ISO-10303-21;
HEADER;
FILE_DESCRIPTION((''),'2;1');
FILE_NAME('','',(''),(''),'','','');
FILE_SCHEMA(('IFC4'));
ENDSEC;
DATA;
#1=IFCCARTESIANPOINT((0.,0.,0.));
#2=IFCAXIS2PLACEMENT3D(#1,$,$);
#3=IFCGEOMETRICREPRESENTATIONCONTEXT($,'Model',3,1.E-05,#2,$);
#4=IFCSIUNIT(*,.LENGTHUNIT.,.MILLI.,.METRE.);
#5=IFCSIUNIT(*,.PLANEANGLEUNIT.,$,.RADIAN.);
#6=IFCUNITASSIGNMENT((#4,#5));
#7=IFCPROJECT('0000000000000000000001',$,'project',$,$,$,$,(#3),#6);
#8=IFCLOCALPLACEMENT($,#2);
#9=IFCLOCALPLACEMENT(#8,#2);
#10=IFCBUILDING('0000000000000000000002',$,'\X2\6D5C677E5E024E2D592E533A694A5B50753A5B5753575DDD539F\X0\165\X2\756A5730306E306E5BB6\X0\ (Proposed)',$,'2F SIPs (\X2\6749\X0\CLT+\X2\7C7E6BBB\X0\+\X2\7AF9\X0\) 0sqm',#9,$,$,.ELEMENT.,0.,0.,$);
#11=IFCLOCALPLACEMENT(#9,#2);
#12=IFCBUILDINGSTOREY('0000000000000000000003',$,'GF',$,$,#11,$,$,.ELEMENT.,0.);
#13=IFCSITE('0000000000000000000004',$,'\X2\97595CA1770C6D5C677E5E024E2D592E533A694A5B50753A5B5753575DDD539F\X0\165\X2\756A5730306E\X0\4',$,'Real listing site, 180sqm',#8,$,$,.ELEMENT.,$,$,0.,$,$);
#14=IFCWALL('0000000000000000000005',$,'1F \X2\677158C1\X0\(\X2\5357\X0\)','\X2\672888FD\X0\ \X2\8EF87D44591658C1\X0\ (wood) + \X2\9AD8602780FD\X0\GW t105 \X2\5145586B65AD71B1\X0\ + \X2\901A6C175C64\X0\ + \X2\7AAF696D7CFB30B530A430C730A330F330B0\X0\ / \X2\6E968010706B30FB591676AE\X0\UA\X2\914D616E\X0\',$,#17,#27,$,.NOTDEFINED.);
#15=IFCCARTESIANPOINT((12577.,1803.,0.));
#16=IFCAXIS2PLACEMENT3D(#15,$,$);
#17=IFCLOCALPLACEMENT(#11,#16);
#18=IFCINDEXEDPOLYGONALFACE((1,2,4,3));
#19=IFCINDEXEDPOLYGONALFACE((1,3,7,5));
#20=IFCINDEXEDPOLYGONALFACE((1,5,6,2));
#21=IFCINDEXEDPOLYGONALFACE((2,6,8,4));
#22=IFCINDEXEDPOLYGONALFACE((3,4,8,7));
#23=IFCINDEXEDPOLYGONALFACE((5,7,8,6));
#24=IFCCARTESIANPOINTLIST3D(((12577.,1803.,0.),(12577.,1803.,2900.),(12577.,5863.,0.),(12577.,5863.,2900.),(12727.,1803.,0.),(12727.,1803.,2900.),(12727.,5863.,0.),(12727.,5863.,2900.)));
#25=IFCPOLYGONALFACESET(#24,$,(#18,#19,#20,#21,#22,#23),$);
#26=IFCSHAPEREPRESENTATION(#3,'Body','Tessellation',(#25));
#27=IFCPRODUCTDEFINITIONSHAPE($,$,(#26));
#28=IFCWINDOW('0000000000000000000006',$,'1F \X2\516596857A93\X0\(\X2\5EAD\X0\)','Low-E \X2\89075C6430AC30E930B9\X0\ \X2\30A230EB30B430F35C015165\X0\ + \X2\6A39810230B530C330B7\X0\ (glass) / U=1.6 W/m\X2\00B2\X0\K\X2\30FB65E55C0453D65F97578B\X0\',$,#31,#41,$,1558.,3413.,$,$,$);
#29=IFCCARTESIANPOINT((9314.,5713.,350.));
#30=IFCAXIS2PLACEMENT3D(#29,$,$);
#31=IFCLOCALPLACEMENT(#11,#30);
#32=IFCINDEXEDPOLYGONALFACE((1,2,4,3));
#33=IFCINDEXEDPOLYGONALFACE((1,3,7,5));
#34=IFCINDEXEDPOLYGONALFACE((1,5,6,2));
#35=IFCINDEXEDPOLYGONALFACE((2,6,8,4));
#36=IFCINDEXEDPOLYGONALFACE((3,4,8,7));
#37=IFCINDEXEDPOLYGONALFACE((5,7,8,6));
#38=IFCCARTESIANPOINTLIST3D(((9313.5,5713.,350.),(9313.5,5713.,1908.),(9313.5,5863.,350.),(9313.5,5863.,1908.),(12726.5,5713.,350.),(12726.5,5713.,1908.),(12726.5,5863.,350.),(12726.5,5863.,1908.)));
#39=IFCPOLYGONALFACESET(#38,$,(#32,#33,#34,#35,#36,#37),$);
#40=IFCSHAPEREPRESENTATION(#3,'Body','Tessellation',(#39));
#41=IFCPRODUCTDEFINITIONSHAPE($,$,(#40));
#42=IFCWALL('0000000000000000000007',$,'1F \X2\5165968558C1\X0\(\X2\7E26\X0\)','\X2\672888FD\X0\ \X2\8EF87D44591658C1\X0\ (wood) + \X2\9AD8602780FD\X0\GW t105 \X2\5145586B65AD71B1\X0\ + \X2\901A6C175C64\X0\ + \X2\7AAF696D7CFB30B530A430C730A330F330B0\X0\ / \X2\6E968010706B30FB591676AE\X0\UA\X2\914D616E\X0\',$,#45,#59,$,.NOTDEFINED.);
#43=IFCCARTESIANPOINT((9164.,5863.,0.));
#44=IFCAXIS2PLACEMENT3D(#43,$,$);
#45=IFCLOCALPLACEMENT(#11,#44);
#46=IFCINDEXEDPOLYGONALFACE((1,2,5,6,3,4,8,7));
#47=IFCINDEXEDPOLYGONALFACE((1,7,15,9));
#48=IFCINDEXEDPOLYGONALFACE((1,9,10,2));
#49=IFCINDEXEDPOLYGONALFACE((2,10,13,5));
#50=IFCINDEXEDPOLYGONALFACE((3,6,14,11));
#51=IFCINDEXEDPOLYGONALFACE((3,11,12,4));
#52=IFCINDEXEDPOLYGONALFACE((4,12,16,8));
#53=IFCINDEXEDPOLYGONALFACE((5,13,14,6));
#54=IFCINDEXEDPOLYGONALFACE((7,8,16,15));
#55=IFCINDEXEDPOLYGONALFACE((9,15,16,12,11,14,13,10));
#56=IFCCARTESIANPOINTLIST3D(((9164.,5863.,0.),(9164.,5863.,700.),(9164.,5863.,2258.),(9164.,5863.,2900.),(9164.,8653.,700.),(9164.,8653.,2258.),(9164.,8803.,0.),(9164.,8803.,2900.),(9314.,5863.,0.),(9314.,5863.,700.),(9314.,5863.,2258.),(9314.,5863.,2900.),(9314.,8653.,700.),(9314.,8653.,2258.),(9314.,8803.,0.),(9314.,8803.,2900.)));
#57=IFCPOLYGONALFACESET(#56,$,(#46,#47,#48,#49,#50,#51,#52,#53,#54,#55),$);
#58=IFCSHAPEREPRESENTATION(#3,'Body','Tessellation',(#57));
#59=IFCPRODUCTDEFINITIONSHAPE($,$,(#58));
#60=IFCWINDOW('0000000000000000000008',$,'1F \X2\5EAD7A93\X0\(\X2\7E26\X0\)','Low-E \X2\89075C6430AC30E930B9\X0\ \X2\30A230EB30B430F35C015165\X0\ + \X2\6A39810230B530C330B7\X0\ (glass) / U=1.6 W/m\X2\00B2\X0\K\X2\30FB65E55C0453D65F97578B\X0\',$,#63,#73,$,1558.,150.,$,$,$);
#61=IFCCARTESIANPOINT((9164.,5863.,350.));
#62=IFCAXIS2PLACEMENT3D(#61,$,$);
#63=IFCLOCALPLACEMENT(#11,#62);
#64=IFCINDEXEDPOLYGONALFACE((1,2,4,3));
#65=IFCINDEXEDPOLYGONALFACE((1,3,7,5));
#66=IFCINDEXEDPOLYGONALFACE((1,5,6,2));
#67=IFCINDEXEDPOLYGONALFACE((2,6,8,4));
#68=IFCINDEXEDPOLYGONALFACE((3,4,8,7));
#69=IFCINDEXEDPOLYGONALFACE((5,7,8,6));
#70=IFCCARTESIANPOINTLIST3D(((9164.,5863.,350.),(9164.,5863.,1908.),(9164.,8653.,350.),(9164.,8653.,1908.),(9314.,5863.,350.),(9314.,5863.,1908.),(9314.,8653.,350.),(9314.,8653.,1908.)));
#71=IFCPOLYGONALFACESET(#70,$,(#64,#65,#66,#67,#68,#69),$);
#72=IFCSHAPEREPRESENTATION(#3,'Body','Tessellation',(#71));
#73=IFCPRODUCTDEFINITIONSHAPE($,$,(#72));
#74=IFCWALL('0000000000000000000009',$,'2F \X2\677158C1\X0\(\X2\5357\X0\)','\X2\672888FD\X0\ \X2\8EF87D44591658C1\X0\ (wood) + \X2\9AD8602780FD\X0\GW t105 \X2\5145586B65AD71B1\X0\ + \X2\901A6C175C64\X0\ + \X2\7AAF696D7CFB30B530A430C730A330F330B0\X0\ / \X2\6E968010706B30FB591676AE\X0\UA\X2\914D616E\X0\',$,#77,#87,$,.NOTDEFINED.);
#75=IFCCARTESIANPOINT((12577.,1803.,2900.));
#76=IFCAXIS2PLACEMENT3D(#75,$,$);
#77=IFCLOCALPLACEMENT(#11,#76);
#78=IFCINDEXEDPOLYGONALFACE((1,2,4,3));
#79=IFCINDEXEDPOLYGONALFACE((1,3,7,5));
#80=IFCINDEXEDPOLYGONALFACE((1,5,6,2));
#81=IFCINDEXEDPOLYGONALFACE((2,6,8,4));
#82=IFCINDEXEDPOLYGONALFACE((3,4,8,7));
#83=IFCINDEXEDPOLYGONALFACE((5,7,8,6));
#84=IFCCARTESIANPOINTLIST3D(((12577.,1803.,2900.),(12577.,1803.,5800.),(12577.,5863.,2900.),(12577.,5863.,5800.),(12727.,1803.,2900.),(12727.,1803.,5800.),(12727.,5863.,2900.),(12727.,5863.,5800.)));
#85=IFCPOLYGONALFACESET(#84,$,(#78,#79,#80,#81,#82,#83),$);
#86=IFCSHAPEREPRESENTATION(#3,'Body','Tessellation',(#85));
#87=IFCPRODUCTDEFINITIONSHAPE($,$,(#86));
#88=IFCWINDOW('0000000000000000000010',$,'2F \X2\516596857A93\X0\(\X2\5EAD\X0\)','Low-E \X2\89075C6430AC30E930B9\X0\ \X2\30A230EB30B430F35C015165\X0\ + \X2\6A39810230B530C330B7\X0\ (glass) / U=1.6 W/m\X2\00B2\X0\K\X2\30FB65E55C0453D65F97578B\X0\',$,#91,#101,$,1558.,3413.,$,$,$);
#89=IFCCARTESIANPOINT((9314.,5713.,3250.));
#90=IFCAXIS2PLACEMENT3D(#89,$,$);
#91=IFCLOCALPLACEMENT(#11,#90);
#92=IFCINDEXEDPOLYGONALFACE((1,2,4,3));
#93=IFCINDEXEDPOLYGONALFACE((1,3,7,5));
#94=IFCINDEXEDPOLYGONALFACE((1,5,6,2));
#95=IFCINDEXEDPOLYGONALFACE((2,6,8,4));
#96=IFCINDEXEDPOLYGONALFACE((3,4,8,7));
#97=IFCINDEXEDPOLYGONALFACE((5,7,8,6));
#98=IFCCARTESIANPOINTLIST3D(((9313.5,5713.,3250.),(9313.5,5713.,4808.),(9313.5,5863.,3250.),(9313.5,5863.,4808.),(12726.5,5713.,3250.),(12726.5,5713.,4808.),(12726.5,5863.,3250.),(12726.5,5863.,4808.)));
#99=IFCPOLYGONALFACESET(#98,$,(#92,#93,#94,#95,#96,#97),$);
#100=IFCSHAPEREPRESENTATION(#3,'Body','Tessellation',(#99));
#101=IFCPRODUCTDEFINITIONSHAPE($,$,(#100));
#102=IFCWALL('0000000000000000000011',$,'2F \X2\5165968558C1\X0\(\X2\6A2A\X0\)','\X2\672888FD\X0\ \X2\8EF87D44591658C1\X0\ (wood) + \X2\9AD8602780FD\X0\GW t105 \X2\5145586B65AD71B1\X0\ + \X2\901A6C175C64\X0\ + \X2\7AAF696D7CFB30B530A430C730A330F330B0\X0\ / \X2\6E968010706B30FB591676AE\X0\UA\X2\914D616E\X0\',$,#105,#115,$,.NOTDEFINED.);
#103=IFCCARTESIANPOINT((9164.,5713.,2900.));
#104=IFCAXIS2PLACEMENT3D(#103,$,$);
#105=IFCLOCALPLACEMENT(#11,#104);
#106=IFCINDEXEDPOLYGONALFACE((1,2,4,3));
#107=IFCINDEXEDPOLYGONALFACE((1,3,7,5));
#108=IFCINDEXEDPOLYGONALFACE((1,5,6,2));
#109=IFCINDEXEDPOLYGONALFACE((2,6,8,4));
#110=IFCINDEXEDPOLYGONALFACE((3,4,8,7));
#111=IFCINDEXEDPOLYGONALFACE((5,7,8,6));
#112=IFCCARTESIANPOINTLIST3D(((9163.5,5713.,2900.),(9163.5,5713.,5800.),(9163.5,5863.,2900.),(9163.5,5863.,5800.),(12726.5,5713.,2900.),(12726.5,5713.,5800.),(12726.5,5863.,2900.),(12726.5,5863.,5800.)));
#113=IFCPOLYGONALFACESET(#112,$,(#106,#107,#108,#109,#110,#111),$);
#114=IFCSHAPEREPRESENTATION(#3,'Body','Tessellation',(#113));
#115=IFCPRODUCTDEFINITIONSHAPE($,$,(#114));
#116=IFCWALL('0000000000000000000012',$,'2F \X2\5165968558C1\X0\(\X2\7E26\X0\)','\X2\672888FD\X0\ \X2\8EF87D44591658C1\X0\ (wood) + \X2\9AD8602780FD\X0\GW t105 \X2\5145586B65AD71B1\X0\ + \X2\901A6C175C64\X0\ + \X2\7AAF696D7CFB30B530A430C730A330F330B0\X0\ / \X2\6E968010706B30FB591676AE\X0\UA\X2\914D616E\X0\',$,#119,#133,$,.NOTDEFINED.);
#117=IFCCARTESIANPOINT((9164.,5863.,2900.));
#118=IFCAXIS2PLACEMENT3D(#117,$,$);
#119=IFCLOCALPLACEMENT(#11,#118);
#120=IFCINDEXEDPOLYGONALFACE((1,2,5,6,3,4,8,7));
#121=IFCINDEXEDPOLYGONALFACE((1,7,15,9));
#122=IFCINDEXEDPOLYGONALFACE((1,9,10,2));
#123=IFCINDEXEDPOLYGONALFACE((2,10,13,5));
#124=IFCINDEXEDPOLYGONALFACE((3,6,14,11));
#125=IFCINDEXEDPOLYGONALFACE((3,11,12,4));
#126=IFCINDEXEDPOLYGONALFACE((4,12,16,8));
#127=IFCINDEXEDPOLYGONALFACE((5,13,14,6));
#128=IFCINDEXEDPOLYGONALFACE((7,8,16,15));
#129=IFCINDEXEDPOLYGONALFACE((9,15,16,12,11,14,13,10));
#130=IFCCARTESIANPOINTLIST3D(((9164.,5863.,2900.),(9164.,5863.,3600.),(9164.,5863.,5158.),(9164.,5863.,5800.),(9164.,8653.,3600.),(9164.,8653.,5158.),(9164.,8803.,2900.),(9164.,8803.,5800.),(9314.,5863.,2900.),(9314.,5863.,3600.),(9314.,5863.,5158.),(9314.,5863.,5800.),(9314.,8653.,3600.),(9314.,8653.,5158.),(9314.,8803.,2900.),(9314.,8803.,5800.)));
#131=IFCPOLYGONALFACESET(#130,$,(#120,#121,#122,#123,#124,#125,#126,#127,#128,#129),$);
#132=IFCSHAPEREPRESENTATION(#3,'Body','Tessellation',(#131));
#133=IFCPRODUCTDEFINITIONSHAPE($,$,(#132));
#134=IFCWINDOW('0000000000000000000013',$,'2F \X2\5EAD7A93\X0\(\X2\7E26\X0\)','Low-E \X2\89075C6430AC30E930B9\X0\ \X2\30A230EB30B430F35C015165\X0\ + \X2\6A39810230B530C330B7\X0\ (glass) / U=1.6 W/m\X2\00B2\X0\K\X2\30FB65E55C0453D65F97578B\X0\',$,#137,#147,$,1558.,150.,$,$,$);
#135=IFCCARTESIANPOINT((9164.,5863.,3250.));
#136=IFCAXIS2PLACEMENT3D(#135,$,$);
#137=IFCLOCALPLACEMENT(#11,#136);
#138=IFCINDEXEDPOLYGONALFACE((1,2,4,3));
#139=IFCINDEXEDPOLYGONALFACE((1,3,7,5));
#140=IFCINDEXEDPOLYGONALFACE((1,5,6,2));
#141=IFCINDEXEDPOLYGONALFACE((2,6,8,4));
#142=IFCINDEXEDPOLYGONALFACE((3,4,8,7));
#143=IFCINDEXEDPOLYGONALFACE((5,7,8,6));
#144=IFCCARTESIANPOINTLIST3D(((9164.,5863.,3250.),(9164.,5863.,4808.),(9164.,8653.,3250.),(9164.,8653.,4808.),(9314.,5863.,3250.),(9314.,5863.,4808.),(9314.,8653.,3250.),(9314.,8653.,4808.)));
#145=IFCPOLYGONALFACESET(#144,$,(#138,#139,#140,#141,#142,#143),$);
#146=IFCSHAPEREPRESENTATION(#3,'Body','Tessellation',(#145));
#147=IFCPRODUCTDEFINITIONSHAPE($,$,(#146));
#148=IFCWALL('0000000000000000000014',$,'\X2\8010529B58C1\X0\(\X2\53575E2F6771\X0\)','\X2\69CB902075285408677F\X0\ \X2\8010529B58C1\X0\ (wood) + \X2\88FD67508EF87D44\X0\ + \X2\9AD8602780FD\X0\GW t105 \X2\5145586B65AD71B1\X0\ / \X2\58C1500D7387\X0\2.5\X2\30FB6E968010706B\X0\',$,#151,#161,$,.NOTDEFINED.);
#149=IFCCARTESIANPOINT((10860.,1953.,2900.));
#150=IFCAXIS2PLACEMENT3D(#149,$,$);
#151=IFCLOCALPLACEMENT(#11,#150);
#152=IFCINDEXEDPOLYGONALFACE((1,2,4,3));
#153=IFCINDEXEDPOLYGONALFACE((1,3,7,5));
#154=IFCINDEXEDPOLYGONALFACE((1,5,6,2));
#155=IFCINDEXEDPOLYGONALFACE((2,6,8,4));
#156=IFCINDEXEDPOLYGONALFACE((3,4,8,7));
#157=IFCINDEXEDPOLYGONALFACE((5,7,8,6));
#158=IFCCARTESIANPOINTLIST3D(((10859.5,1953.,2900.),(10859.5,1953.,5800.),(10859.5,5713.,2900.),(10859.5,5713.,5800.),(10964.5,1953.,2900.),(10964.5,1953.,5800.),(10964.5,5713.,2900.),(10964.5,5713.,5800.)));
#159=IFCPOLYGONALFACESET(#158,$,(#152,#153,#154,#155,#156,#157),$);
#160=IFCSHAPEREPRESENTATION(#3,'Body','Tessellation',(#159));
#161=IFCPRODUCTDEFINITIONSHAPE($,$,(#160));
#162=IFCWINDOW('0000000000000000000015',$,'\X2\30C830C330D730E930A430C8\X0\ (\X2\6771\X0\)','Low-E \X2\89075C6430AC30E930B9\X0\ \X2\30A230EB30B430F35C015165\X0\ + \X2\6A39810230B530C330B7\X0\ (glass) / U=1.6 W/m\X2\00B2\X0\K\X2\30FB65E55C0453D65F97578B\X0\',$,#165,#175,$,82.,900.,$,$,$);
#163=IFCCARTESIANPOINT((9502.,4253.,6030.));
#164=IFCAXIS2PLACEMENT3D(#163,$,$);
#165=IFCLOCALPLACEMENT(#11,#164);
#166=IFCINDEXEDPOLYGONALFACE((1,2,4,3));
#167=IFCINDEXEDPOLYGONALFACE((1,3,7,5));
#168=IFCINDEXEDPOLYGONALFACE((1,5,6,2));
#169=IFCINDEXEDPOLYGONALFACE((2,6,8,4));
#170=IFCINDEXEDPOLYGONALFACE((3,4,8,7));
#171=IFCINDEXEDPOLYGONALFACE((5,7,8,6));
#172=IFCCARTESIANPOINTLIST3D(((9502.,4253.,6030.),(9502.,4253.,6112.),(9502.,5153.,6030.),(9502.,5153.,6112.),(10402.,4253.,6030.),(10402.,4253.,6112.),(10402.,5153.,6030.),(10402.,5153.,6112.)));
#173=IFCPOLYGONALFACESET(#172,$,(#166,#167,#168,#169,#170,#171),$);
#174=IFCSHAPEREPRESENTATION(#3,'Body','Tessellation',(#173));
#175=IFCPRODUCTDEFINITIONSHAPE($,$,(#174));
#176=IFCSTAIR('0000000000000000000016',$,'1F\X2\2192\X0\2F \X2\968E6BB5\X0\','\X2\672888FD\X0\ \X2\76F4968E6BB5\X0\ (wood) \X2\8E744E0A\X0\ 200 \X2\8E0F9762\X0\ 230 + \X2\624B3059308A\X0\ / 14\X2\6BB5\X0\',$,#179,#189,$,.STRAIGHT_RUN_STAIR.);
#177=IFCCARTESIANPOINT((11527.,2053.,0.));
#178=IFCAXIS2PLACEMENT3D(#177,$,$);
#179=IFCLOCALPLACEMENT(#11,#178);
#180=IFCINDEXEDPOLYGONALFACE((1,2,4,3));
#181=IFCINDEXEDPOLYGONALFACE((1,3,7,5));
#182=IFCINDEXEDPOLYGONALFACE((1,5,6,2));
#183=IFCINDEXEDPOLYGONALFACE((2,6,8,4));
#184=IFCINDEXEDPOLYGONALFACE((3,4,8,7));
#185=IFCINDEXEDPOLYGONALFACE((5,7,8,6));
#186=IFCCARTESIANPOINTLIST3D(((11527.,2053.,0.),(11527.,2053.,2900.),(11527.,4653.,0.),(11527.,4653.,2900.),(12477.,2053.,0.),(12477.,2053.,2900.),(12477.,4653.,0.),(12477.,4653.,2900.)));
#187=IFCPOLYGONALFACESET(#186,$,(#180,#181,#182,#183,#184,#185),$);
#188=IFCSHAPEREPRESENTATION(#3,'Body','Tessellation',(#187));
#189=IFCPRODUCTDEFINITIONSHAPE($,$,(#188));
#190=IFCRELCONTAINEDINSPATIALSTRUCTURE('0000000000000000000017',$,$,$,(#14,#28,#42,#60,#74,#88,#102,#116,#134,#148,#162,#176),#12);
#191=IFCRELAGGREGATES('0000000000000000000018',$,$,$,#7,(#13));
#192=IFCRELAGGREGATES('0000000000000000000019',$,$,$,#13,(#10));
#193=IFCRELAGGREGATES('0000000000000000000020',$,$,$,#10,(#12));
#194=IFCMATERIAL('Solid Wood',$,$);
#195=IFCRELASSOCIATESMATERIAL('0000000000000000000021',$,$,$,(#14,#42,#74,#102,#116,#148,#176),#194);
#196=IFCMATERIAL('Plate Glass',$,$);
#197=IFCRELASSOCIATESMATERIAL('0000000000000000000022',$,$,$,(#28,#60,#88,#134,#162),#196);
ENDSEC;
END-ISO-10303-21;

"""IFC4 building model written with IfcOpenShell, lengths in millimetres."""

from ifc_helpers import new_model, si_unit, frame, frame_2d, origin, place, context, project, spatial, rectangle, extrude, material, element, fill, save


model = new_model("IFC4")

# Units and contexts
model_context = context("Model", 3, precision=1e-05, world=origin())
ifc_project = project(units=[si_unit("LENGTHUNIT", "METRE", prefix="MILLI"), si_unit("PLANEANGLEUNIT", "RADIAN")], contexts=[model_context])

# Site, building, storey
site_placement = place(None, origin())
site = spatial("IfcSite", under=ifc_project, at=site_placement, Name="静岡県浜松市中央区楊子町字南川原165番地の4", ObjectType="Real listing site, 180sqm", CompositionType="ELEMENT", RefElevation=0.0)
building_placement = place(site_placement, origin())
building = spatial("IfcBuilding", under=site, at=building_placement, Name="浜松市中央区楊子町字南川原165番地のの家 (Proposed)", ObjectType="2F SIPs (杉CLT+籾殻+竹) 0sqm", CompositionType="ELEMENT", ElevationOfRefHeight=0.0, ElevationOfTerrain=0.0)
storey_placement = place(building_placement, origin())
storey = spatial("IfcBuildingStorey", under=building, at=storey_placement, Name="GF", CompositionType="ELEMENT", Elevation=0.0)

# Shared definitions
ifc_material_1 = material(Name="Solid Wood")

# Wall, opening, window
wall_1_placement = place(storey_placement, frame((12577.0, 1803.0, 0.0)))
wall_1 = element("IfcWall", 1, at=wall_1_placement, inside=storey, material=ifc_material_1, Name="1F 東壁(南)", Description="木製 軸組外壁 (wood) + 高性能GW t105 充填断熱 + 通気層 + 窯業系サイディング / 準耐火・外皮UA配慮", PredefinedType="NOTDEFINED", context=model_context, shape_type="SweptSolid", body=[
    extrude(rectangle(XDim=150.0, YDim=4060.0, at=frame_2d((75.0, 2030.0))), frame((12577.0, 1803.0, 0.0)), (0.0, 0.0, 1.0), 2900.0),
])
opening_1_placement = place(storey_placement, frame((9314.0, 5713.0, 350.0)))
opening_1 = element("IfcOpeningElement", 2, at=opening_1_placement, cuts=wall_1, PredefinedType="NOTDEFINED", context=model_context, shape_type="SweptSolid", body=[
    extrude(rectangle(XDim=3413.0, YDim=150.0, at=frame_2d((1706.0, 75.0))), frame((9314.0, 5713.0, 350.0)), (0.0, 0.0, 1.0), 1558.0),
])
ifc_material_2 = material(Name="Plate Glass")
window_1_placement = place(storey_placement, frame((9314.0, 5713.0, 350.0)))
window_1 = element("IfcWindow", 3, at=window_1_placement, inside=storey, material=ifc_material_2, Name="1F 入隅窓(庭)", Description="Low-E 複層ガラス アルゴン封入 + 樹脂サッシ (glass) / U=1.6 W/m²K・日射取得型", OverallHeight=1558.0, OverallWidth=3413.0, context=model_context, shape_type="SweptSolid", body=[
    extrude(rectangle(XDim=3413.0, YDim=150.0, at=frame_2d((1706.0, 75.0))), frame((9314.0, 5713.0, 350.0)), (0.0, 0.0, 1.0), 1558.0),
])
fill(opening_1, window_1)

# Wall, opening, window
wall_2_placement = place(storey_placement, frame((9164.0, 5863.0, 0.0)))
wall_2 = element("IfcWall", 4, at=wall_2_placement, inside=storey, material=ifc_material_1, Name="1F 入隅壁(縦)", Description="木製 軸組外壁 (wood) + 高性能GW t105 充填断熱 + 通気層 + 窯業系サイディング / 準耐火・外皮UA配慮", PredefinedType="NOTDEFINED", context=model_context, shape_type="SweptSolid", body=[
    extrude(rectangle(XDim=150.0, YDim=2940.0, at=frame_2d((75.0, 1470.0))), frame((9164.0, 5863.0, 0.0)), (0.0, 0.0, 1.0), 2900.0),
])
opening_2_placement = place(storey_placement, frame((9164.0, 5863.0, 350.0)))
opening_2 = element("IfcOpeningElement", 5, at=opening_2_placement, cuts=wall_2, PredefinedType="NOTDEFINED", context=model_context, shape_type="SweptSolid", body=[
    extrude(rectangle(XDim=150.0, YDim=2790.0, at=frame_2d((75.0, 1395.0))), frame((9164.0, 5863.0, 350.0)), (0.0, 0.0, 1.0), 1558.0),
])
window_2_placement = place(storey_placement, frame((9164.0, 5863.0, 350.0)))
window_2 = element("IfcWindow", 6, at=window_2_placement, inside=storey, material=ifc_material_2, Name="1F 庭窓(縦)", Description="Low-E 複層ガラス アルゴン封入 + 樹脂サッシ (glass) / U=1.6 W/m²K・日射取得型", OverallHeight=1558.0, OverallWidth=150.0, context=model_context, shape_type="SweptSolid", body=[
    extrude(rectangle(XDim=150.0, YDim=2790.0, at=frame_2d((75.0, 1395.0))), frame((9164.0, 5863.0, 350.0)), (0.0, 0.0, 1.0), 1558.0),
])
fill(opening_2, window_2)

# Wall, opening, window
wall_3_placement = place(storey_placement, frame((12577.0, 1803.0, 2900.0)))
wall_3 = element("IfcWall", 7, at=wall_3_placement, inside=storey, material=ifc_material_1, Name="2F 東壁(南)", Description="木製 軸組外壁 (wood) + 高性能GW t105 充填断熱 + 通気層 + 窯業系サイディング / 準耐火・外皮UA配慮", PredefinedType="NOTDEFINED", context=model_context, shape_type="SweptSolid", body=[
    extrude(rectangle(XDim=150.0, YDim=4060.0, at=frame_2d((75.0, 2030.0))), frame((12577.0, 1803.0, 2900.0)), (0.0, 0.0, 1.0), 2900.0),
])
opening_3_placement = place(storey_placement, frame((9314.0, 5713.0, 3250.0)))
opening_3 = element("IfcOpeningElement", 8, at=opening_3_placement, cuts=wall_3, PredefinedType="NOTDEFINED", context=model_context, shape_type="SweptSolid", body=[
    extrude(rectangle(XDim=3413.0, YDim=150.0, at=frame_2d((1706.0, 75.0))), frame((9314.0, 5713.0, 3250.0)), (0.0, 0.0, 1.0), 1558.0),
])
window_3_placement = place(storey_placement, frame((9314.0, 5713.0, 3250.0)))
window_3 = element("IfcWindow", 9, at=window_3_placement, inside=storey, material=ifc_material_2, Name="2F 入隅窓(庭)", Description="Low-E 複層ガラス アルゴン封入 + 樹脂サッシ (glass) / U=1.6 W/m²K・日射取得型", OverallHeight=1558.0, OverallWidth=3413.0, context=model_context, shape_type="SweptSolid", body=[
    extrude(rectangle(XDim=3413.0, YDim=150.0, at=frame_2d((1706.0, 75.0))), frame((9314.0, 5713.0, 3250.0)), (0.0, 0.0, 1.0), 1558.0),
])
fill(opening_3, window_3)

# Wall
wall_4_placement = place(storey_placement, frame((9164.0, 5713.0, 2900.0)))
element("IfcWall", 10, at=wall_4_placement, inside=storey, material=ifc_material_1, Name="2F 入隅壁(横)", Description="木製 軸組外壁 (wood) + 高性能GW t105 充填断熱 + 通気層 + 窯業系サイディング / 準耐火・外皮UA配慮", PredefinedType="NOTDEFINED", context=model_context, shape_type="SweptSolid", body=[
    extrude(rectangle(XDim=3563.0, YDim=150.0, at=frame_2d((1781.0, 75.0))), frame((9164.0, 5713.0, 2900.0)), (0.0, 0.0, 1.0), 2900.0),
])

# Wall, opening, window
wall_5_placement = place(storey_placement, frame((9164.0, 5863.0, 2900.0)))
wall_5 = element("IfcWall", 11, at=wall_5_placement, inside=storey, material=ifc_material_1, Name="2F 入隅壁(縦)", Description="木製 軸組外壁 (wood) + 高性能GW t105 充填断熱 + 通気層 + 窯業系サイディング / 準耐火・外皮UA配慮", PredefinedType="NOTDEFINED", context=model_context, shape_type="SweptSolid", body=[
    extrude(rectangle(XDim=150.0, YDim=2940.0, at=frame_2d((75.0, 1470.0))), frame((9164.0, 5863.0, 2900.0)), (0.0, 0.0, 1.0), 2900.0),
])
opening_4_placement = place(storey_placement, frame((9164.0, 5863.0, 3250.0)))
opening_4 = element("IfcOpeningElement", 12, at=opening_4_placement, cuts=wall_5, PredefinedType="NOTDEFINED", context=model_context, shape_type="SweptSolid", body=[
    extrude(rectangle(XDim=150.0, YDim=2790.0, at=frame_2d((75.0, 1395.0))), frame((9164.0, 5863.0, 3250.0)), (0.0, 0.0, 1.0), 1558.0),
])
window_4_placement = place(storey_placement, frame((9164.0, 5863.0, 3250.0)))
window_4 = element("IfcWindow", 13, at=window_4_placement, inside=storey, material=ifc_material_2, Name="2F 庭窓(縦)", Description="Low-E 複層ガラス アルゴン封入 + 樹脂サッシ (glass) / U=1.6 W/m²K・日射取得型", OverallHeight=1558.0, OverallWidth=150.0, context=model_context, shape_type="SweptSolid", body=[
    extrude(rectangle(XDim=150.0, YDim=2790.0, at=frame_2d((75.0, 1395.0))), frame((9164.0, 5863.0, 3250.0)), (0.0, 0.0, 1.0), 1558.0),
])
fill(opening_4, window_4)

# Wall
wall_6_placement = place(storey_placement, frame((10860.0, 1953.0, 2900.0)))
element("IfcWall", 14, at=wall_6_placement, inside=storey, material=ifc_material_1, Name="耐力壁(南帯東)", Description="構造用合板 耐力壁 (wood) + 製材軸組 + 高性能GW t105 充填断熱 / 壁倍率2.5・準耐火", PredefinedType="NOTDEFINED", context=model_context, shape_type="SweptSolid", body=[
    extrude(rectangle(XDim=105.0, YDim=3760.0, at=frame_2d((52.0, 1880.0))), frame((10860.0, 1953.0, 2900.0)), (0.0, 0.0, 1.0), 2900.0),
])

# Window
window_5_placement = place(storey_placement, frame((9502.0, 4253.0, 6030.0)))
element("IfcWindow", 15, at=window_5_placement, inside=storey, material=ifc_material_2, Name="トップライト (東)", Description="Low-E 複層ガラス アルゴン封入 + 樹脂サッシ (glass) / U=1.6 W/m²K・日射取得型", OverallHeight=82.0, OverallWidth=900.0, context=model_context, shape_type="SweptSolid", body=[
    extrude(rectangle(XDim=900.0, YDim=900.0, at=frame_2d((450.0, 450.0))), frame((9502.0, 4253.0, 6030.0)), (0.0, 0.0, 1.0), 82.0),
])

# Stair
stair_placement = place(storey_placement, frame((11527.0, 2053.0, 0.0)))
element("IfcStair", 16, at=stair_placement, inside=storey, material=ifc_material_1, Name="1F→2F 階段", Description="木製 直階段 (wood) 蹴上 200 踏面 230 + 手すり / 14段", PredefinedType="STRAIGHT_RUN_STAIR", context=model_context, shape_type="SweptSolid", body=[
    extrude(rectangle(XDim=950.0, YDim=2600.0, at=frame_2d((475.0, 1300.0))), frame((11527.0, 2053.0, 0.0)), (0.0, 0.0, 1.0), 2900.0),
])

save(model, "model.ifc")
